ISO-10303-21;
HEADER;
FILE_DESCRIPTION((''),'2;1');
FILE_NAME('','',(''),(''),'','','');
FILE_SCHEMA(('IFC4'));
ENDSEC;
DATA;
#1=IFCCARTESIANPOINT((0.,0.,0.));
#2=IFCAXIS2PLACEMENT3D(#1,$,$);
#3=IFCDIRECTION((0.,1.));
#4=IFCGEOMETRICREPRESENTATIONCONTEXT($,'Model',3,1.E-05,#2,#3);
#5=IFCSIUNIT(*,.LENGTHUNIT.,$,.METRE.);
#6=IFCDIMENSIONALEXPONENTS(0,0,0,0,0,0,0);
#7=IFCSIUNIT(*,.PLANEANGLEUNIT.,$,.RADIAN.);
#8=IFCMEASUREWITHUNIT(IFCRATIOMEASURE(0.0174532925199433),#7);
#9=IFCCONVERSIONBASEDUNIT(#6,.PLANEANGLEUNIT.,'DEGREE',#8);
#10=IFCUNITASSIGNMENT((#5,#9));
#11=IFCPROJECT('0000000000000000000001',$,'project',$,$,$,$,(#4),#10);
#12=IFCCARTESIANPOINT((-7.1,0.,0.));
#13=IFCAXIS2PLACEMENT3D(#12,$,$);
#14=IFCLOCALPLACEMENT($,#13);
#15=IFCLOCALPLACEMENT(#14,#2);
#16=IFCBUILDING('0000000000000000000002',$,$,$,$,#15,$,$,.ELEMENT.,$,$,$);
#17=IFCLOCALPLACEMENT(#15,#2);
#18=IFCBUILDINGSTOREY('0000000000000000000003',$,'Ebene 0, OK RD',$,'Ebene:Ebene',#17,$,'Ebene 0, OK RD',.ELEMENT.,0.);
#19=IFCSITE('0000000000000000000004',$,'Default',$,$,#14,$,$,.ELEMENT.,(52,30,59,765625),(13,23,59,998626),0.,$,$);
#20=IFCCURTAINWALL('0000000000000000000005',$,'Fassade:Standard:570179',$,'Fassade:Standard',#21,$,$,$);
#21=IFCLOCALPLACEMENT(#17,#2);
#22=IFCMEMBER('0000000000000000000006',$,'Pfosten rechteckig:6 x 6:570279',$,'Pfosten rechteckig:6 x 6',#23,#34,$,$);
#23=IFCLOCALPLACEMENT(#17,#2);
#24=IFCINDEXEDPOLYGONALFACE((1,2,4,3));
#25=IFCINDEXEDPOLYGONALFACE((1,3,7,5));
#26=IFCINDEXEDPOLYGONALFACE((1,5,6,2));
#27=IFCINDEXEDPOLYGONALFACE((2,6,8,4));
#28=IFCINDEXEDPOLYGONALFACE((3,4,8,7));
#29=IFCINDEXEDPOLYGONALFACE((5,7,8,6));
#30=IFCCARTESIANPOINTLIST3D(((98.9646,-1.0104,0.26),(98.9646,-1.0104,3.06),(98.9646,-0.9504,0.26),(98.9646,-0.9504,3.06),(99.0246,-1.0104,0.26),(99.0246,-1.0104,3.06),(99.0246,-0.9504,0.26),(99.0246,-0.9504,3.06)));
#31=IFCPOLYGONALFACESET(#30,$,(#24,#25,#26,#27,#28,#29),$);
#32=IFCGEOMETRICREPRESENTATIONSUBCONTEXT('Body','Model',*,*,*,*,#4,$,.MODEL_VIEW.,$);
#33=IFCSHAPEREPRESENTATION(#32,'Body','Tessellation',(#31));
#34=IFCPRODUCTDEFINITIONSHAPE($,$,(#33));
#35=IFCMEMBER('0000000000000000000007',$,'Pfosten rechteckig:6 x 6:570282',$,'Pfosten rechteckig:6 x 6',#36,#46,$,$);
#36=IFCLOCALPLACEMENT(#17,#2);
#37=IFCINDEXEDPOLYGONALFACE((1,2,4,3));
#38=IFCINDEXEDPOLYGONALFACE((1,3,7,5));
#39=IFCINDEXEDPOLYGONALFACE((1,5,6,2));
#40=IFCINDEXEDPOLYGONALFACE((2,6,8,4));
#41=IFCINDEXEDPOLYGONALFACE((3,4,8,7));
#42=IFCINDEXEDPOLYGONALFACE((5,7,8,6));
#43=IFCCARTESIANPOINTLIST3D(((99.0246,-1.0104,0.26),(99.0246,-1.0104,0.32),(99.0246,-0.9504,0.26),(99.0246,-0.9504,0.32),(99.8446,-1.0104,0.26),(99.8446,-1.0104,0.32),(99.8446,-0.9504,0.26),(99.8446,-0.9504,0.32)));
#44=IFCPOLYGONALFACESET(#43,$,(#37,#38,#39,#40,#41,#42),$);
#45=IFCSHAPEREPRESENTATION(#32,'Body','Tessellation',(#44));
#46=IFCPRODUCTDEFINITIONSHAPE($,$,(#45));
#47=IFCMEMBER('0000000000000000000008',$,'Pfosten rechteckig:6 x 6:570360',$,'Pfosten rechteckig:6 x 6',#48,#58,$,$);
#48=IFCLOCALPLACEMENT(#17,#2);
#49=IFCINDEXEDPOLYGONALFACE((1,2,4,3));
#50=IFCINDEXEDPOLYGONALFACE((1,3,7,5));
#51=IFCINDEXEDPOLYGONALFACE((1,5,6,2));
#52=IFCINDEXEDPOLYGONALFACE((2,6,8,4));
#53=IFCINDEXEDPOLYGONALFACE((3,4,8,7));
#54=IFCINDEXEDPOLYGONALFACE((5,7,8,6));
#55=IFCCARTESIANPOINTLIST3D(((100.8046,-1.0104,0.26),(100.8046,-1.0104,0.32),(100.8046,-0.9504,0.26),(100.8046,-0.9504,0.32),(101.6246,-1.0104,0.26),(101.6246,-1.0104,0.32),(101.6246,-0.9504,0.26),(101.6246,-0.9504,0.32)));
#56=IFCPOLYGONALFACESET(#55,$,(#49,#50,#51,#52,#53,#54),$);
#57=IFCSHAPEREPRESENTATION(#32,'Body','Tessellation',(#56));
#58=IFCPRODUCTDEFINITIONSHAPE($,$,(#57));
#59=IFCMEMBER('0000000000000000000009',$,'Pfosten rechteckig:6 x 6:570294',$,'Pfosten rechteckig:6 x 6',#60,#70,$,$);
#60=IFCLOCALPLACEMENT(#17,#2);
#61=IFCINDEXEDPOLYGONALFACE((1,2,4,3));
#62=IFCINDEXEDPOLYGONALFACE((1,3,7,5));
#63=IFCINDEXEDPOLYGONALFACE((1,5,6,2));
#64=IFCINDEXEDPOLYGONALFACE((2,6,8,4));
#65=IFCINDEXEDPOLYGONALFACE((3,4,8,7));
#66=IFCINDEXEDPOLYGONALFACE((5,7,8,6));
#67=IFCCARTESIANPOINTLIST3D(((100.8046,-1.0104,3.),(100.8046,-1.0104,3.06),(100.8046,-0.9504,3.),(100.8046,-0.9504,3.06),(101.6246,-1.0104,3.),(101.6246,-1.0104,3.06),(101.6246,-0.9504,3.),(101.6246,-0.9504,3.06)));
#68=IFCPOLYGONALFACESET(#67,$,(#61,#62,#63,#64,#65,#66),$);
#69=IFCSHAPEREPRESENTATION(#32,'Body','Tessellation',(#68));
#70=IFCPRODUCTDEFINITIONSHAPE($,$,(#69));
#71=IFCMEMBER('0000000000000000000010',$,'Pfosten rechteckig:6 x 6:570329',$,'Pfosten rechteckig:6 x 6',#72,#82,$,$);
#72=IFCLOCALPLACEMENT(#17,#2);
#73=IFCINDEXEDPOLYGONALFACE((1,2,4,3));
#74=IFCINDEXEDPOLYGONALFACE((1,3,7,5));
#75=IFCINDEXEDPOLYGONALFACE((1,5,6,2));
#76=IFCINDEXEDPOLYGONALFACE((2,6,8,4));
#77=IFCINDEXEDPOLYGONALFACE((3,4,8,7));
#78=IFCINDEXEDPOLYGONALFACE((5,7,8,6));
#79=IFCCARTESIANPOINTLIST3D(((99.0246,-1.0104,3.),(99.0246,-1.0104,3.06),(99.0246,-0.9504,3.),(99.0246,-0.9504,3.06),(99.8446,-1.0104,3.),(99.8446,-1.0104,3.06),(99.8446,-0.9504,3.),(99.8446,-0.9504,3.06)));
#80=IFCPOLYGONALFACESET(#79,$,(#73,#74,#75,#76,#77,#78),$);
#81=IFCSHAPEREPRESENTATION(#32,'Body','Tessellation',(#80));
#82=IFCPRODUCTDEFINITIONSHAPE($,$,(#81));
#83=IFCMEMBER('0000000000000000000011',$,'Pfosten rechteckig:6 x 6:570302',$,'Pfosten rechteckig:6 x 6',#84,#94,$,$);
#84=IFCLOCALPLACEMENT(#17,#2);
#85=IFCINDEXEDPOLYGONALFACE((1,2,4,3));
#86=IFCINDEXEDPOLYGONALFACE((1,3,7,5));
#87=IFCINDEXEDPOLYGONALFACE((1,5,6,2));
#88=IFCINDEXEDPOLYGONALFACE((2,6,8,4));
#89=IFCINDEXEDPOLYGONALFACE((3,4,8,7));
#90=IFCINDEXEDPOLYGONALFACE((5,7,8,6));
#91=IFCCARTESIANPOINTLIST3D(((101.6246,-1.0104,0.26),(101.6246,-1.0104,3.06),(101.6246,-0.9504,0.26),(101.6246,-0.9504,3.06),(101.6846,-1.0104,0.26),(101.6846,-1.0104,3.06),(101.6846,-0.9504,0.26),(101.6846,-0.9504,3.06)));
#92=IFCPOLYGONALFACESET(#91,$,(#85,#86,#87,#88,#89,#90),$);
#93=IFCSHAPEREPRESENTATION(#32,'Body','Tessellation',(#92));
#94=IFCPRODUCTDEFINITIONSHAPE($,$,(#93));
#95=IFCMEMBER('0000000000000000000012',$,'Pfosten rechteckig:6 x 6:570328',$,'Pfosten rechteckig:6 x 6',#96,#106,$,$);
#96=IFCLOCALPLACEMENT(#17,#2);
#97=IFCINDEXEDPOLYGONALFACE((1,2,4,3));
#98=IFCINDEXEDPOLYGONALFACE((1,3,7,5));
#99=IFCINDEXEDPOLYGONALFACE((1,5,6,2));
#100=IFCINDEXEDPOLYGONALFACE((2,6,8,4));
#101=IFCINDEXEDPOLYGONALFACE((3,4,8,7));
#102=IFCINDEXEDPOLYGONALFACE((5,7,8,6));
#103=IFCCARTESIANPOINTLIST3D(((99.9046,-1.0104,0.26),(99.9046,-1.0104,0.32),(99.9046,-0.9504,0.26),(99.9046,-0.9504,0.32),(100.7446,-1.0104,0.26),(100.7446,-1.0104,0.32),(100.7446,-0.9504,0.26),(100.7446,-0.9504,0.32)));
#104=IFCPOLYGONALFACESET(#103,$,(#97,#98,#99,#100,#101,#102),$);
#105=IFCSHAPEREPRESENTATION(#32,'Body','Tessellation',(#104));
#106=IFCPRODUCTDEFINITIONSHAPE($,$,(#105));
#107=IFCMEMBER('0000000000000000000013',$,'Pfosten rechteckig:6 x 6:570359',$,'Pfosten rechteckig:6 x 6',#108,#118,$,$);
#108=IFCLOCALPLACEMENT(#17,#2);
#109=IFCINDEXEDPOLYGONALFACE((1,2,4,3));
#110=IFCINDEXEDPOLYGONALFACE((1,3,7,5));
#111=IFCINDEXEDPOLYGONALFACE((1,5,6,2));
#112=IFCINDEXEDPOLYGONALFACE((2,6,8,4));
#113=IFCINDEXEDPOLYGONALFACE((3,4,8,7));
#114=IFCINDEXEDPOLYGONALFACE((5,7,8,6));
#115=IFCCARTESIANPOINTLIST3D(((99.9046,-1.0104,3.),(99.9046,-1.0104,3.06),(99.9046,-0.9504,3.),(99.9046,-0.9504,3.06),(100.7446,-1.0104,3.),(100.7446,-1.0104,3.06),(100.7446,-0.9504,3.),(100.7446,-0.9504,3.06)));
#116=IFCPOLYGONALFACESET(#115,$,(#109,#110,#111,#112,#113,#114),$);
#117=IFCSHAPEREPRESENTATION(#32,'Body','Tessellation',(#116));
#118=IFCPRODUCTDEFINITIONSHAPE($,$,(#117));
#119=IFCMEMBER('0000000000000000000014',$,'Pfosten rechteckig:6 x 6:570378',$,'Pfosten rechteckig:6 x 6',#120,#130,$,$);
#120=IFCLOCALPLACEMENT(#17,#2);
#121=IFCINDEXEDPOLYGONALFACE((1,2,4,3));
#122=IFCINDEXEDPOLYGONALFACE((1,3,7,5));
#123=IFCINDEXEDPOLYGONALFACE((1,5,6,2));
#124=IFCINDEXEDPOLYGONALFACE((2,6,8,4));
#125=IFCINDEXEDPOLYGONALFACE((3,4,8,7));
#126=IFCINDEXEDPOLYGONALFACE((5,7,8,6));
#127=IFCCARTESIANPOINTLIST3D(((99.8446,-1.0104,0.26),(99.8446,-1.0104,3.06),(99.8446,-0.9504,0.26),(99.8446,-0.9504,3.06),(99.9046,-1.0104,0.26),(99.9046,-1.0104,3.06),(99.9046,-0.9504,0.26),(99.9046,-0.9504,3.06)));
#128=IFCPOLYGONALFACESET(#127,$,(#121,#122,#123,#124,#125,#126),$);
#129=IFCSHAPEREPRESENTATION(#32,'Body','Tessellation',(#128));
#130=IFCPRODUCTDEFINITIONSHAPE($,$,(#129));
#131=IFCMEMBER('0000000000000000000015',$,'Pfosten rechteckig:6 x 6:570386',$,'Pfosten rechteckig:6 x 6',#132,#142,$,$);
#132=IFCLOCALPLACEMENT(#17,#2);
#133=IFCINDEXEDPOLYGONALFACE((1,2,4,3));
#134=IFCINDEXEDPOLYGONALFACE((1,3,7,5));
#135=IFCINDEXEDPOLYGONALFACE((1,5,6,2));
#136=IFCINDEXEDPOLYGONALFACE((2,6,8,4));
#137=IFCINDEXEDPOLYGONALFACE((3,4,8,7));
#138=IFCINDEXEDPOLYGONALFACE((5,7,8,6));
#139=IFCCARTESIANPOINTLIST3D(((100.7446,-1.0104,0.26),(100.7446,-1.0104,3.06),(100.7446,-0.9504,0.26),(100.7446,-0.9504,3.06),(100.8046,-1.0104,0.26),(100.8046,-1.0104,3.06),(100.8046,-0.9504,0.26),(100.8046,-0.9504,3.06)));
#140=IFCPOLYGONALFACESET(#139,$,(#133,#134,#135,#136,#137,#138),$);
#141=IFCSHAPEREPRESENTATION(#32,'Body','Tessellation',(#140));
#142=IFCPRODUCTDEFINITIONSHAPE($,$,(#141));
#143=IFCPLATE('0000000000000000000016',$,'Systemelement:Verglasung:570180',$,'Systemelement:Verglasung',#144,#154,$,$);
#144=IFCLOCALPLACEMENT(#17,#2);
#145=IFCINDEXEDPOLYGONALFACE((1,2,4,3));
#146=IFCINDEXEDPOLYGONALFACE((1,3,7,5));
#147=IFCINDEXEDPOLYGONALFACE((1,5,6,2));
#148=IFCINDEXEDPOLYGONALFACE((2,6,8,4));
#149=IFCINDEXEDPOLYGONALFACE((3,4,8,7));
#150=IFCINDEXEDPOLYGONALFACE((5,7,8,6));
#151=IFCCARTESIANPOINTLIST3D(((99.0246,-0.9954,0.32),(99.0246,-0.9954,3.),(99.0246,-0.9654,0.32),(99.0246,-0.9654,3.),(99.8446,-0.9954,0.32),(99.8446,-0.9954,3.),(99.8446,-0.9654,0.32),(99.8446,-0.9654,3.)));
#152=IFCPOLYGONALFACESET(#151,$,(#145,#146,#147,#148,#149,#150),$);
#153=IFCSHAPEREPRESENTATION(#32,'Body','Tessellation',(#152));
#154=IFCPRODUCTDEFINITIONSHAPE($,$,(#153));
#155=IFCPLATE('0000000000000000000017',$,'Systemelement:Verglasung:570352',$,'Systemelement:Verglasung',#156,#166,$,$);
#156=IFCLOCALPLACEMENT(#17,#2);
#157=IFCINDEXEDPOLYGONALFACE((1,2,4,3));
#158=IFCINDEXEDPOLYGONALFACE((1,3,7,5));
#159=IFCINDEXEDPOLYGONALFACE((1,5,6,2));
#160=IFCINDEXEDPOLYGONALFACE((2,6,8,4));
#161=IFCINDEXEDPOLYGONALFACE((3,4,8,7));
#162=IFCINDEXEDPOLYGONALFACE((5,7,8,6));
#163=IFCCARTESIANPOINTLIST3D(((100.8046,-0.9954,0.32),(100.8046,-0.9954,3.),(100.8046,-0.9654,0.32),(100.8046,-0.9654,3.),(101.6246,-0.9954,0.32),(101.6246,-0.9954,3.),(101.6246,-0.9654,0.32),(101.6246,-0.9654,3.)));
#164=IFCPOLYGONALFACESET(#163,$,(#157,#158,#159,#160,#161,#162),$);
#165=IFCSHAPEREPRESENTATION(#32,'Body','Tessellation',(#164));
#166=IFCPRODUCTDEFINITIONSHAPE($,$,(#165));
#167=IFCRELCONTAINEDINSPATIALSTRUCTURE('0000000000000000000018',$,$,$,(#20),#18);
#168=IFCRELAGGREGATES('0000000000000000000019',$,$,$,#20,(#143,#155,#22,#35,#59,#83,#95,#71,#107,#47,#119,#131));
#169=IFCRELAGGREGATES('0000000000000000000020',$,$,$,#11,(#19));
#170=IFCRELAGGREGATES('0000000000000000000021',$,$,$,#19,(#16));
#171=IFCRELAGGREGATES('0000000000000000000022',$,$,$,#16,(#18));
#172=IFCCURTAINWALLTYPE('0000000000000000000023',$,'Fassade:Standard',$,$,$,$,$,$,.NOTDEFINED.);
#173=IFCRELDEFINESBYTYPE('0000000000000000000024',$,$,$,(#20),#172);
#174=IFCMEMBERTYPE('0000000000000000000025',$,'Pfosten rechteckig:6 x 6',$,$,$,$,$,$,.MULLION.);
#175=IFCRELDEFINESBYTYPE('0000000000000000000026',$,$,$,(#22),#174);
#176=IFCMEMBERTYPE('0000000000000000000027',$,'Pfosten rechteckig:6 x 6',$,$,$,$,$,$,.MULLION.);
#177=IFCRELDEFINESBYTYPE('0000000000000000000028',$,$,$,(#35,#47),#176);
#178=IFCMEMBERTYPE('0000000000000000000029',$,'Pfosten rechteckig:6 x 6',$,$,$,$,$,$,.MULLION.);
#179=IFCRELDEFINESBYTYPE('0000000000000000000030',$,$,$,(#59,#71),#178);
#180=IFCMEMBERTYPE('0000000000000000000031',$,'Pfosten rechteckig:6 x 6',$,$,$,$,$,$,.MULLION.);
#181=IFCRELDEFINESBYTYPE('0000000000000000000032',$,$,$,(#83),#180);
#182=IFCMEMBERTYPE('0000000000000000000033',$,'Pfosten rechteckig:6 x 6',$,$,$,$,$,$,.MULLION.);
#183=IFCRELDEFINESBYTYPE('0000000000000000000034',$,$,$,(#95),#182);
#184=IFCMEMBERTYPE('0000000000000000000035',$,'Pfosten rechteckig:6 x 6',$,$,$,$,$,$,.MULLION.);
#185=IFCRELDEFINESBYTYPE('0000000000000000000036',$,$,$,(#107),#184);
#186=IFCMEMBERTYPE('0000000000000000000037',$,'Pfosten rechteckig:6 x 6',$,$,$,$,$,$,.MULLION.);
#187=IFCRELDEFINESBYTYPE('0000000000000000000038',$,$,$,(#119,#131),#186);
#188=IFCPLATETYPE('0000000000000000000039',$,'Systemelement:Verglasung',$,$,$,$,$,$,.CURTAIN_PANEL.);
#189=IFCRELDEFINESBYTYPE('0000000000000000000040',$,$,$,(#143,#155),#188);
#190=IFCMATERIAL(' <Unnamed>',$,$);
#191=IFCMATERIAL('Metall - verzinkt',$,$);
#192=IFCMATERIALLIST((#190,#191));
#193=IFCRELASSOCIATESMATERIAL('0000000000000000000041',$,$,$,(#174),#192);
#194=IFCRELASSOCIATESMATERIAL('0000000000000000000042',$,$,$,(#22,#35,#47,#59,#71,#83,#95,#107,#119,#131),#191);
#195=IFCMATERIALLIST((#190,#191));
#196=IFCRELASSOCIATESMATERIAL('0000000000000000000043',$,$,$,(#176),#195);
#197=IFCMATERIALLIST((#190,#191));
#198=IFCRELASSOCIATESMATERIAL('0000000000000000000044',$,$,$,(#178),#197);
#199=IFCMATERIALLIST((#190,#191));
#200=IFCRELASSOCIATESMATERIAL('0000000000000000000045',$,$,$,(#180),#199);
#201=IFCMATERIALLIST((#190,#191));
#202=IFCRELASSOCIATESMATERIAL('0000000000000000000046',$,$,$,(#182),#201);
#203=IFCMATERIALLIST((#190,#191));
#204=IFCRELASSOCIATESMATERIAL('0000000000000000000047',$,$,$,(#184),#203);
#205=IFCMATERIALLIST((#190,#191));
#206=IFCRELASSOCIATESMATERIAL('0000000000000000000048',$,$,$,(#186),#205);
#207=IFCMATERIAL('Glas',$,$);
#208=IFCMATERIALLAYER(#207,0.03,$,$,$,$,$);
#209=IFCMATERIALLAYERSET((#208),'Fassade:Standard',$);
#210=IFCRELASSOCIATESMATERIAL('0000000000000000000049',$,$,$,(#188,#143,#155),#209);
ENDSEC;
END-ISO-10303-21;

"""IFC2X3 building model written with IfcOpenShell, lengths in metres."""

from ifc_helpers import new_model, entity, si_unit, converted_unit, direction, frame, origin, origin_2d_with_axis, place, context, subcontext, project, spatial, rectangle, extrude, source, transform, mapped, material, material_list, layer, layer_set, layer_usage, type_object, type_shapes, element, aggregate, save


model = new_model("IFC2X3")

# Units and contexts
model_context = context("Model", 3, precision=1e-05, world=origin(), true_north=direction((0.0, 1.0)))
body_context = subcontext(model_context, "Body", "Model", "MODEL_VIEW")
ifc_project = project(units=[si_unit("LENGTHUNIT", "METRE"), converted_unit("PLANEANGLEUNIT", "DEGREE", entity("IfcRatioMeasure", 0.0174532925199433), si_unit("PLANEANGLEUNIT", "RADIAN"), dimensions=[0, 0, 0, 0, 0, 0, 0])], contexts=[model_context])

# Site, building, storey
site_placement = place(None, frame((-7.1, 0.0, 0.0)))
site = spatial("IfcSite", under=ifc_project, at=site_placement, Name="Default", CompositionType="ELEMENT", RefLatitude=(52, 30, 59, 765625), RefLongitude=(13, 23, 59, 998626), RefElevation=0.0)
building_placement = place(site_placement, origin())
building = spatial("IfcBuilding", under=site, at=building_placement, CompositionType="ELEMENT")
storey_placement = place(building_placement, origin())
storey = spatial("IfcBuildingStorey", under=building, at=storey_placement, Name="Ebene 0, OK RD", ObjectType="Ebene:Ebene", LongName="Ebene 0, OK RD", CompositionType="ELEMENT", Elevation=0.0)

# Curtain wall, members, plates
curtain_wall_type = type_object("IfcCurtainWallType", Name="Fassade:Standard", PredefinedType="NOTDEFINED")
curtain_wall_placement = place(storey_placement, origin())
curtain_wall = element("IfcCurtainWall", 1, at=curtain_wall_placement, inside=storey, type_object=curtain_wall_type, Name="Fassade:Standard:570179", ObjectType="Fassade:Standard")
ifc_material_1 = material(Name="Metall - verzinkt")
ifc_material_2 = material(Name=" <Unnamed>")
ifc_material_list_1 = material_list([ifc_material_2, ifc_material_1])
member_type_1 = type_object("IfcMemberType", Name="Pfosten rechteckig:6 x 6", PredefinedType="MULLION", material=ifc_material_list_1)
shared_shape_1 = source(origin(), body_context, "Body", "SweptSolid", [
    extrude(rectangle(XDim=0.06, YDim=0.06, at=origin_2d_with_axis()), frame((-0.03, 0.0, -2.8), z_axis=(0.0, 0.0, 1.0), x_axis=(0.0, -1.0, 0.0)), (0.0, 0.0, 1.0), 2.8),
])
type_shapes(member_type_1, [shared_shape_1])
member_1_placement = place(storey_placement, frame((98.9646, -0.9804, 3.06), z_axis=(0.0, 0.0, 1.0), x_axis=(-1.0, 0.0, 0.0)))
member_1 = element("IfcMember", 2, at=member_1_placement, type_object=member_type_1, material=ifc_material_1, Name="Pfosten rechteckig:6 x 6:570279", ObjectType="Pfosten rechteckig:6 x 6", context=body_context, shape_type="MappedRepresentation", body=[
    mapped(shared_shape_1, transform((0.0, 0.0, 0.0), scale=1.0)),
])
ifc_material_list_2 = material_list([ifc_material_2, ifc_material_1])
member_type_2 = type_object("IfcMemberType", Name="Pfosten rechteckig:6 x 6", PredefinedType="MULLION", material=ifc_material_list_2)
shared_shape_2 = source(origin(), body_context, "Body", "SweptSolid", [
    extrude(rectangle(XDim=0.06, YDim=0.06, at=origin_2d_with_axis()), frame((-0.03, 0.0, -0.82), z_axis=(0.0, 0.0, 1.0), x_axis=(0.0, -1.0, 0.0)), (0.0, 0.0, 1.0), 0.82),
])
type_shapes(member_type_2, [shared_shape_2])
member_2_placement = place(storey_placement, frame((99.0246, -0.9804, 0.26), z_axis=(-1.0, 0.0, 0.0), x_axis=(0.0, 0.0, -1.0)))
member_2 = element("IfcMember", 3, at=member_2_placement, type_object=member_type_2, material=ifc_material_1, Name="Pfosten rechteckig:6 x 6:570282", ObjectType="Pfosten rechteckig:6 x 6", context=body_context, shape_type="MappedRepresentation", body=[
    mapped(shared_shape_2, transform((0.0, 0.0, 0.0), scale=1.0)),
])
member_3_placement = place(storey_placement, frame((100.8046, -0.9804, 0.26), z_axis=(-1.0, 0.0, 0.0), x_axis=(0.0, 0.0, -1.0)))
member_3 = element("IfcMember", 4, at=member_3_placement, type_object=member_type_2, material=ifc_material_1, Name="Pfosten rechteckig:6 x 6:570360", ObjectType="Pfosten rechteckig:6 x 6", context=body_context, shape_type="MappedRepresentation", body=[
    mapped(shared_shape_2, transform((0.0, 0.0, 0.0), scale=1.0)),
])
ifc_material_list_3 = material_list([ifc_material_2, ifc_material_1])
member_type_3 = type_object("IfcMemberType", Name="Pfosten rechteckig:6 x 6", PredefinedType="MULLION", material=ifc_material_list_3)
shared_shape_3 = source(origin(), body_context, "Body", "SweptSolid", [
    extrude(rectangle(XDim=0.06, YDim=0.06, at=origin_2d_with_axis()), frame((-0.03, 0.0, -0.82), z_axis=(0.0, 0.0, 1.0), x_axis=(0.0, -1.0, 0.0)), (0.0, 0.0, 1.0), 0.82),
])
type_shapes(member_type_3, [shared_shape_3])
member_4_placement = place(storey_placement, frame((101.6246, -0.9804, 3.06), z_axis=(1.0, 0.0, 0.0), x_axis=(0.0, 0.0, 1.0)))
member_4 = element("IfcMember", 5, at=member_4_placement, type_object=member_type_3, material=ifc_material_1, Name="Pfosten rechteckig:6 x 6:570294", ObjectType="Pfosten rechteckig:6 x 6", context=body_context, shape_type="MappedRepresentation", body=[
    mapped(shared_shape_3, transform((0.0, 0.0, 0.0), scale=1.0)),
])
member_5_placement = place(storey_placement, frame((99.8446, -0.9804, 3.06), z_axis=(1.0, 0.0, 0.0), x_axis=(0.0, 0.0, 1.0)))
member_5 = element("IfcMember", 6, at=member_5_placement, type_object=member_type_3, material=ifc_material_1, Name="Pfosten rechteckig:6 x 6:570329", ObjectType="Pfosten rechteckig:6 x 6", context=body_context, shape_type="MappedRepresentation", body=[
    mapped(shared_shape_3, transform((0.0, 0.0, 0.0), scale=1.0)),
])
ifc_material_list_4 = material_list([ifc_material_2, ifc_material_1])
member_type_4 = type_object("IfcMemberType", Name="Pfosten rechteckig:6 x 6", PredefinedType="MULLION", material=ifc_material_list_4)
shared_shape_4 = source(origin(), body_context, "Body", "SweptSolid", [
    extrude(rectangle(XDim=0.06, YDim=0.06, at=origin_2d_with_axis()), frame((-0.03, 0.0, -2.8), z_axis=(0.0, 0.0, 1.0), x_axis=(0.0, -1.0, 0.0)), (0.0, 0.0, 1.0), 2.8),
])
type_shapes(member_type_4, [shared_shape_4])
member_6_placement = place(storey_placement, frame((101.6846, -0.9804, 0.26), z_axis=(0.0, 0.0, -1.0), x_axis=(1.0, 0.0, 0.0)))
member_6 = element("IfcMember", 7, at=member_6_placement, type_object=member_type_4, material=ifc_material_1, Name="Pfosten rechteckig:6 x 6:570302", ObjectType="Pfosten rechteckig:6 x 6", context=body_context, shape_type="MappedRepresentation", body=[
    mapped(shared_shape_4, transform((0.0, 0.0, 0.0), scale=1.0)),
])
ifc_material_list_5 = material_list([ifc_material_2, ifc_material_1])
member_type_5 = type_object("IfcMemberType", Name="Pfosten rechteckig:6 x 6", PredefinedType="MULLION", material=ifc_material_list_5)
shared_shape_5 = source(origin(), body_context, "Body", "SweptSolid", [
    extrude(rectangle(XDim=0.06, YDim=0.06, at=origin_2d_with_axis()), frame((-0.03, 0.0, -0.84), z_axis=(0.0, 0.0, 1.0), x_axis=(0.0, -1.0, 0.0)), (0.0, 0.0, 1.0), 0.84),
])
type_shapes(member_type_5, [shared_shape_5])
member_7_placement = place(storey_placement, frame((99.9046, -0.9804, 0.26), z_axis=(-1.0, 0.0, 0.0), x_axis=(0.0, 0.0, -1.0)))
member_7 = element("IfcMember", 8, at=member_7_placement, type_object=member_type_5, material=ifc_material_1, Name="Pfosten rechteckig:6 x 6:570328", ObjectType="Pfosten rechteckig:6 x 6", context=body_context, shape_type="MappedRepresentation", body=[
    mapped(shared_shape_5, transform((0.0, 0.0, 0.0), scale=1.0)),
])
ifc_material_list_6 = material_list([ifc_material_2, ifc_material_1])
member_type_6 = type_object("IfcMemberType", Name="Pfosten rechteckig:6 x 6", PredefinedType="MULLION", material=ifc_material_list_6)
shared_shape_6 = source(origin(), body_context, "Body", "SweptSolid", [
    extrude(rectangle(XDim=0.06, YDim=0.06, at=origin_2d_with_axis()), frame((-0.03, 0.0, -0.84), z_axis=(0.0, 0.0, 1.0), x_axis=(0.0, -1.0, 0.0)), (0.0, 0.0, 1.0), 0.84),
])
type_shapes(member_type_6, [shared_shape_6])
member_8_placement = place(storey_placement, frame((100.7446, -0.9804, 3.06), z_axis=(1.0, 0.0, 0.0), x_axis=(0.0, 0.0, 1.0)))
member_8 = element("IfcMember", 9, at=member_8_placement, type_object=member_type_6, material=ifc_material_1, Name="Pfosten rechteckig:6 x 6:570359", ObjectType="Pfosten rechteckig:6 x 6", context=body_context, shape_type="MappedRepresentation", body=[
    mapped(shared_shape_6, transform((0.0, 0.0, 0.0), scale=1.0)),
])
ifc_material_list_7 = material_list([ifc_material_2, ifc_material_1])
member_type_7 = type_object("IfcMemberType", Name="Pfosten rechteckig:6 x 6", PredefinedType="MULLION", material=ifc_material_list_7)
shared_shape_7 = source(origin(), body_context, "Body", "SweptSolid", [
    extrude(rectangle(XDim=0.06, YDim=0.06, at=origin_2d_with_axis()), frame((0.0, 0.0, -2.8), z_axis=(0.0, 0.0, 1.0), x_axis=(0.0, -1.0, 0.0)), (0.0, 0.0, 1.0), 2.8),
])
type_shapes(member_type_7, [shared_shape_7])
member_9_placement = place(storey_placement, frame((99.8746, -0.9804, 0.26), z_axis=(0.0, 0.0, -1.0), x_axis=(1.0, 0.0, 0.0)))
member_9 = element("IfcMember", 10, at=member_9_placement, type_object=member_type_7, material=ifc_material_1, Name="Pfosten rechteckig:6 x 6:570378", ObjectType="Pfosten rechteckig:6 x 6", context=body_context, shape_type="MappedRepresentation", body=[
    mapped(shared_shape_7, transform((0.0, 0.0, 0.0), scale=1.0)),
])
member_10_placement = place(storey_placement, frame((100.7746, -0.9804, 0.26), z_axis=(0.0, 0.0, -1.0), x_axis=(1.0, 0.0, 0.0)))
member_10 = element("IfcMember", 11, at=member_10_placement, type_object=member_type_7, material=ifc_material_1, Name="Pfosten rechteckig:6 x 6:570386", ObjectType="Pfosten rechteckig:6 x 6", context=body_context, shape_type="MappedRepresentation", body=[
    mapped(shared_shape_7, transform((0.0, 0.0, 0.0), scale=1.0)),
])
ifc_material_3 = material(Name="Glas")
ifc_layer_1 = layer(ifc_material_3, 0.03)
ifc_layer_set_1 = layer_set([ifc_layer_1], Name="Fassade:Standard")
ifc_layer_usage_1 = layer_usage(ifc_layer_set_1, "AXIS3", "POSITIVE", 0.0)
plate_type_1 = type_object("IfcPlateType", Name="Systemelement:Verglasung", PredefinedType="CURTAIN_PANEL", material=ifc_layer_set_1)
shared_shape_8 = source(origin(), body_context, "Body", "SweptSolid", [
    extrude(rectangle(XDim=0.03, YDim=0.82, at=origin_2d_with_axis()), frame((0.0, 0.0, 0.0), z_axis=(0.0, 0.0, 1.0), x_axis=(0.0, 1.0, 0.0)), (0.0, 0.0, 1.0), 2.68),
])
type_shapes(plate_type_1, [shared_shape_8])
plate_1_placement = place(curtain_wall_placement, frame((99.4346, -0.9804, 0.32)))
plate_1 = element("IfcPlate", 12, at=plate_1_placement, type_object=plate_type_1, material=ifc_layer_usage_1, Name="Systemelement:Verglasung:570180", ObjectType="Systemelement:Verglasung", context=body_context, shape_type="MappedRepresentation", body=[
    mapped(shared_shape_8, transform((0.0, 0.0, 0.0), scale=1.0)),
])
ifc_layer_usage_2 = layer_usage(ifc_layer_set_1, "AXIS3", "POSITIVE", 0.0)
plate_2_placement = place(curtain_wall_placement, frame((101.2146, -0.9804, 0.32)))
plate_2 = element("IfcPlate", 13, at=plate_2_placement, type_object=plate_type_1, material=ifc_layer_usage_2, Name="Systemelement:Verglasung:570352", ObjectType="Systemelement:Verglasung", context=body_context, shape_type="MappedRepresentation", body=[
    mapped(shared_shape_8, transform((0.0, 0.0, 0.0), scale=1.0)),
])
aggregate(curtain_wall, [plate_1, plate_2, member_1, member_2, member_4, member_6, member_7, member_5, member_8, member_3, member_9, member_10])

save(model, "model.ifc")
